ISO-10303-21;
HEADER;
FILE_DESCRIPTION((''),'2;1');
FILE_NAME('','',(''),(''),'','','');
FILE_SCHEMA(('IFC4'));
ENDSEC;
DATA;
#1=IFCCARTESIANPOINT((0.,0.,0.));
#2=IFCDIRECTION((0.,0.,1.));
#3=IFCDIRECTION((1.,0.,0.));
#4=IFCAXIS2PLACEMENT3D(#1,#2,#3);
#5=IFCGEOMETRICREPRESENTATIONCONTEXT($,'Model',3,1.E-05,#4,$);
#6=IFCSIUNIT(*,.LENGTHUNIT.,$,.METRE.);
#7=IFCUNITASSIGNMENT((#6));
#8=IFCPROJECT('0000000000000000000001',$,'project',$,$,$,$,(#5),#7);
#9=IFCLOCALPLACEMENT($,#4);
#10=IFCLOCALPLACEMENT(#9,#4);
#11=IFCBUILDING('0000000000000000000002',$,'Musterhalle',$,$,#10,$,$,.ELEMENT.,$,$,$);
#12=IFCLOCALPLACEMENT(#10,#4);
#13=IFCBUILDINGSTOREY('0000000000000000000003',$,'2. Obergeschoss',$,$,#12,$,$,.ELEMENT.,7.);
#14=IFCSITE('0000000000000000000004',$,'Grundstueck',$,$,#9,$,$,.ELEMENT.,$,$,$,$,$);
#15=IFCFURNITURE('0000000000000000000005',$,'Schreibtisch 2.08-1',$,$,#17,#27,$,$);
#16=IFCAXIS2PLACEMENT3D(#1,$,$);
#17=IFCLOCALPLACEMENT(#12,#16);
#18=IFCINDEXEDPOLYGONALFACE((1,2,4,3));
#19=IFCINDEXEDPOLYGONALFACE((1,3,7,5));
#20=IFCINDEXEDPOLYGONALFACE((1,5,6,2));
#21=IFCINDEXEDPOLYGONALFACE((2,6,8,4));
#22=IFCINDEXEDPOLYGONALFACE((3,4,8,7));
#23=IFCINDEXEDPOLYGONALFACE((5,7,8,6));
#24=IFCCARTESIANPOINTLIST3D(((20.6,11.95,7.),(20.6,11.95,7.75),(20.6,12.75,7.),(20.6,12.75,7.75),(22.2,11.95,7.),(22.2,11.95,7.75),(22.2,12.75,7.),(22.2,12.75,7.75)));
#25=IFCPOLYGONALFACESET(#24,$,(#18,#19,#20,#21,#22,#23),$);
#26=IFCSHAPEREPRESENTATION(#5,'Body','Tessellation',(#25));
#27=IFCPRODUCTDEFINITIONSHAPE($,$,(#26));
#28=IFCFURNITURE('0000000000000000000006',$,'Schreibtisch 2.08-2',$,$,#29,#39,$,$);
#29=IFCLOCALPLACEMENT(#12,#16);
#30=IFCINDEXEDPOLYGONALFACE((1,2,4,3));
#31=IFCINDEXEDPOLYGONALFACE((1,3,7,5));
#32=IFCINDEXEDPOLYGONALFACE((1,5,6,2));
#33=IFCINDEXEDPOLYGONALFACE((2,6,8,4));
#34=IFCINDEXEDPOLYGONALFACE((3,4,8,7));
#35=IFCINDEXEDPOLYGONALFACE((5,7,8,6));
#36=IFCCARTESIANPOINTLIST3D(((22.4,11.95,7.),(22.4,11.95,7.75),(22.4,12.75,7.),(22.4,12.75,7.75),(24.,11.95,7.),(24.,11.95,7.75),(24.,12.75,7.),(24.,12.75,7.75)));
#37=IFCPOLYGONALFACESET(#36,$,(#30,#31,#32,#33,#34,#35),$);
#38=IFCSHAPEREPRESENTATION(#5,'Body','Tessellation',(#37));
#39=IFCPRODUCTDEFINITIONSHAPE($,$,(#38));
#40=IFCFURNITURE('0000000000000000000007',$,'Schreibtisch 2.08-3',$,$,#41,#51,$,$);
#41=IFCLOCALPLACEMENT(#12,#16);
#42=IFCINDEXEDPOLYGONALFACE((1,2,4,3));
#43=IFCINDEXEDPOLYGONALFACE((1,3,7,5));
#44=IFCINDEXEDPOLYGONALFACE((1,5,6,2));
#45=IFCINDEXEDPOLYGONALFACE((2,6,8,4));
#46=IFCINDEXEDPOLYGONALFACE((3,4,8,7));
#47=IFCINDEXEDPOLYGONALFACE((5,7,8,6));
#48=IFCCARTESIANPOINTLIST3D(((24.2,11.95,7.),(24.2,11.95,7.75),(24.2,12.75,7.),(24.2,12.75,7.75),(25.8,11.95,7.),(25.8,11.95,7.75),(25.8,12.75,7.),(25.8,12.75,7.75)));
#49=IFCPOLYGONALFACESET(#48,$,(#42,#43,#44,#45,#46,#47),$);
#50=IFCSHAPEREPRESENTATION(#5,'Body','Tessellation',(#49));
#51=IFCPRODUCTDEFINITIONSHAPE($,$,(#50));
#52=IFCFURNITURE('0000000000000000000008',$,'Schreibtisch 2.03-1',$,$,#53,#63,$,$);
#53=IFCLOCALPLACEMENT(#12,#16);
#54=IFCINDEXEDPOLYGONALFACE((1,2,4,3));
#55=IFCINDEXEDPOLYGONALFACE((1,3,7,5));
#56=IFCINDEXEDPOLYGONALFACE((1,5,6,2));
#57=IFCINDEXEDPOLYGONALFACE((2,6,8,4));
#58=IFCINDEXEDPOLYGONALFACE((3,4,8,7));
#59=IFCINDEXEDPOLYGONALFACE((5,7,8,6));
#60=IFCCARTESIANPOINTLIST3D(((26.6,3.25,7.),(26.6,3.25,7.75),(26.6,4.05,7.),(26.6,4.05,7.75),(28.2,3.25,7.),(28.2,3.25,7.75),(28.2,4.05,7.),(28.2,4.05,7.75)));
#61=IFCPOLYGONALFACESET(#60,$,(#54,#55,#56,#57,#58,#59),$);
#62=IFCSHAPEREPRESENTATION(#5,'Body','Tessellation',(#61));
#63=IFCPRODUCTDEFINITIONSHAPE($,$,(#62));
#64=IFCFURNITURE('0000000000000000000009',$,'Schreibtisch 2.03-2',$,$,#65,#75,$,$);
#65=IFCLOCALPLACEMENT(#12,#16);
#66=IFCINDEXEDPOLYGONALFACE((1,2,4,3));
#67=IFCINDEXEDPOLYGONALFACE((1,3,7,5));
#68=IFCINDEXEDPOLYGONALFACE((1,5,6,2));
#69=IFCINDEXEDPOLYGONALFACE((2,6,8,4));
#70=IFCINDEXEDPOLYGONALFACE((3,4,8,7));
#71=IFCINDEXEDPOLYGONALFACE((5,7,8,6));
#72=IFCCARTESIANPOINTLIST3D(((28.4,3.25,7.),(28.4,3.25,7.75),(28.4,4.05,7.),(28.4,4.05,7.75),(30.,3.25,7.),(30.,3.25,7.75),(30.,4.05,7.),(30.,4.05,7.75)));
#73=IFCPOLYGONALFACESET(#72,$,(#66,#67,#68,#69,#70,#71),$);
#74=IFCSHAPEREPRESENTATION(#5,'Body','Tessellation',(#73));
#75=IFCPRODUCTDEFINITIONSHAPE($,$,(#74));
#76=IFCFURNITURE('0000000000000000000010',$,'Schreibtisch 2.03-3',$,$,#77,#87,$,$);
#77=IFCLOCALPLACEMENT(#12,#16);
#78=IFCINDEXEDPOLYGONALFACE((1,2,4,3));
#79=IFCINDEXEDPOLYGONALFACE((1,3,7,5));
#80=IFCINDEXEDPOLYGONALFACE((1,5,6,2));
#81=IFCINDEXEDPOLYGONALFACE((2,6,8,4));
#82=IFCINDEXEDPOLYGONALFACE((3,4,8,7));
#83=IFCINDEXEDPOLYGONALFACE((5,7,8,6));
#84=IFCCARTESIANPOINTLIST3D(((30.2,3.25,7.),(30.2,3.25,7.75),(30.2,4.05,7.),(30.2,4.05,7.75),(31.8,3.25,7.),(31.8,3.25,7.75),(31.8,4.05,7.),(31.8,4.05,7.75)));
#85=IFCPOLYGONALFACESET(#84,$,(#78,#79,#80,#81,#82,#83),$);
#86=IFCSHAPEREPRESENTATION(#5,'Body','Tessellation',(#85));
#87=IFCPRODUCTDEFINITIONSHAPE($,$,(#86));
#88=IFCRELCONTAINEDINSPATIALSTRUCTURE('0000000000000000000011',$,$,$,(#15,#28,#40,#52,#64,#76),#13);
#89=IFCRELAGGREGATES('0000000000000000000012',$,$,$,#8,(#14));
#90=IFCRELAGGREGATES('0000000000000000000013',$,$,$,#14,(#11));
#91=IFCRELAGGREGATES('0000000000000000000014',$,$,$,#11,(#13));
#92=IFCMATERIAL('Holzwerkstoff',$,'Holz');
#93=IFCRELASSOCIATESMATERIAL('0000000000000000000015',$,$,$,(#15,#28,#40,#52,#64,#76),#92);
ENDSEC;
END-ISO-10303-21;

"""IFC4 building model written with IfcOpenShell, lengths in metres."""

from ifc_helpers import new_model, si_unit, frame, origin_with_axes, origin_2d, place, context, project, spatial, rectangle, extrude, material, element, save


model = new_model("IFC4")

# Units and contexts
model_context = context("Model", 3, precision=1e-05, world=origin_with_axes())
ifc_project = project(units=[si_unit("LENGTHUNIT", "METRE")], contexts=[model_context])

# Site, building, storey
site_placement = place(None, origin_with_axes())
site = spatial("IfcSite", under=ifc_project, at=site_placement, Name="Grundstueck", CompositionType="ELEMENT")
building_placement = place(site_placement, origin_with_axes())
building = spatial("IfcBuilding", under=site, at=building_placement, Name="Musterhalle", CompositionType="ELEMENT")
storey_placement = place(building_placement, origin_with_axes())
storey = spatial("IfcBuildingStorey", under=building, at=storey_placement, Name="2. Obergeschoss", CompositionType="ELEMENT", Elevation=7.0)

# Shared definitions
placement = place(storey_placement, origin_with_axes())

# Shared definitions
ifc_material_1 = material(Name="Holzwerkstoff", Category="Holz")

# Furniture
element("IfcFurniture", 1, at=placement, inside=storey, material=ifc_material_1, Name="Schreibtisch 2.08-1", context=model_context, shape_type="SweptSolid", body=[
    extrude(rectangle(XDim=1.6, YDim=0.8, at=origin_2d()), frame((21.4, 12.35, 7.0), z_axis=(0.0, 0.0, 1.0), x_axis=(1.0, 0.0, 0.0)), (0.0, 0.0, 1.0), 0.75),
])
element("IfcFurniture", 2, at=placement, inside=storey, material=ifc_material_1, Name="Schreibtisch 2.08-2", context=model_context, shape_type="SweptSolid", body=[
    extrude(rectangle(XDim=1.6, YDim=0.8, at=origin_2d()), frame((23.2, 12.35, 7.0), z_axis=(0.0, 0.0, 1.0), x_axis=(1.0, 0.0, 0.0)), (0.0, 0.0, 1.0), 0.75),
])
element("IfcFurniture", 3, at=placement, inside=storey, material=ifc_material_1, Name="Schreibtisch 2.08-3", context=model_context, shape_type="SweptSolid", body=[
    extrude(rectangle(XDim=1.6, YDim=0.8, at=origin_2d()), frame((25.0, 12.35, 7.0), z_axis=(0.0, 0.0, 1.0), x_axis=(1.0, 0.0, 0.0)), (0.0, 0.0, 1.0), 0.75),
])
element("IfcFurniture", 4, at=placement, inside=storey, material=ifc_material_1, Name="Schreibtisch 2.03-1", context=model_context, shape_type="SweptSolid", body=[
    extrude(rectangle(XDim=1.6, YDim=0.8, at=origin_2d()), frame((27.4, 3.65, 7.0), z_axis=(0.0, 0.0, 1.0), x_axis=(1.0, 0.0, 0.0)), (0.0, 0.0, 1.0), 0.75),
])
element("IfcFurniture", 5, at=placement, inside=storey, material=ifc_material_1, Name="Schreibtisch 2.03-2", context=model_context, shape_type="SweptSolid", body=[
    extrude(rectangle(XDim=1.6, YDim=0.8, at=origin_2d()), frame((29.2, 3.65, 7.0), z_axis=(0.0, 0.0, 1.0), x_axis=(1.0, 0.0, 0.0)), (0.0, 0.0, 1.0), 0.75),
])
element("IfcFurniture", 6, at=placement, inside=storey, material=ifc_material_1, Name="Schreibtisch 2.03-3", context=model_context, shape_type="SweptSolid", body=[
    extrude(rectangle(XDim=1.6, YDim=0.8, at=origin_2d()), frame((31.0, 3.65, 7.0), z_axis=(0.0, 0.0, 1.0), x_axis=(1.0, 0.0, 0.0)), (0.0, 0.0, 1.0), 0.75),
])

save(model, "model.ifc")
